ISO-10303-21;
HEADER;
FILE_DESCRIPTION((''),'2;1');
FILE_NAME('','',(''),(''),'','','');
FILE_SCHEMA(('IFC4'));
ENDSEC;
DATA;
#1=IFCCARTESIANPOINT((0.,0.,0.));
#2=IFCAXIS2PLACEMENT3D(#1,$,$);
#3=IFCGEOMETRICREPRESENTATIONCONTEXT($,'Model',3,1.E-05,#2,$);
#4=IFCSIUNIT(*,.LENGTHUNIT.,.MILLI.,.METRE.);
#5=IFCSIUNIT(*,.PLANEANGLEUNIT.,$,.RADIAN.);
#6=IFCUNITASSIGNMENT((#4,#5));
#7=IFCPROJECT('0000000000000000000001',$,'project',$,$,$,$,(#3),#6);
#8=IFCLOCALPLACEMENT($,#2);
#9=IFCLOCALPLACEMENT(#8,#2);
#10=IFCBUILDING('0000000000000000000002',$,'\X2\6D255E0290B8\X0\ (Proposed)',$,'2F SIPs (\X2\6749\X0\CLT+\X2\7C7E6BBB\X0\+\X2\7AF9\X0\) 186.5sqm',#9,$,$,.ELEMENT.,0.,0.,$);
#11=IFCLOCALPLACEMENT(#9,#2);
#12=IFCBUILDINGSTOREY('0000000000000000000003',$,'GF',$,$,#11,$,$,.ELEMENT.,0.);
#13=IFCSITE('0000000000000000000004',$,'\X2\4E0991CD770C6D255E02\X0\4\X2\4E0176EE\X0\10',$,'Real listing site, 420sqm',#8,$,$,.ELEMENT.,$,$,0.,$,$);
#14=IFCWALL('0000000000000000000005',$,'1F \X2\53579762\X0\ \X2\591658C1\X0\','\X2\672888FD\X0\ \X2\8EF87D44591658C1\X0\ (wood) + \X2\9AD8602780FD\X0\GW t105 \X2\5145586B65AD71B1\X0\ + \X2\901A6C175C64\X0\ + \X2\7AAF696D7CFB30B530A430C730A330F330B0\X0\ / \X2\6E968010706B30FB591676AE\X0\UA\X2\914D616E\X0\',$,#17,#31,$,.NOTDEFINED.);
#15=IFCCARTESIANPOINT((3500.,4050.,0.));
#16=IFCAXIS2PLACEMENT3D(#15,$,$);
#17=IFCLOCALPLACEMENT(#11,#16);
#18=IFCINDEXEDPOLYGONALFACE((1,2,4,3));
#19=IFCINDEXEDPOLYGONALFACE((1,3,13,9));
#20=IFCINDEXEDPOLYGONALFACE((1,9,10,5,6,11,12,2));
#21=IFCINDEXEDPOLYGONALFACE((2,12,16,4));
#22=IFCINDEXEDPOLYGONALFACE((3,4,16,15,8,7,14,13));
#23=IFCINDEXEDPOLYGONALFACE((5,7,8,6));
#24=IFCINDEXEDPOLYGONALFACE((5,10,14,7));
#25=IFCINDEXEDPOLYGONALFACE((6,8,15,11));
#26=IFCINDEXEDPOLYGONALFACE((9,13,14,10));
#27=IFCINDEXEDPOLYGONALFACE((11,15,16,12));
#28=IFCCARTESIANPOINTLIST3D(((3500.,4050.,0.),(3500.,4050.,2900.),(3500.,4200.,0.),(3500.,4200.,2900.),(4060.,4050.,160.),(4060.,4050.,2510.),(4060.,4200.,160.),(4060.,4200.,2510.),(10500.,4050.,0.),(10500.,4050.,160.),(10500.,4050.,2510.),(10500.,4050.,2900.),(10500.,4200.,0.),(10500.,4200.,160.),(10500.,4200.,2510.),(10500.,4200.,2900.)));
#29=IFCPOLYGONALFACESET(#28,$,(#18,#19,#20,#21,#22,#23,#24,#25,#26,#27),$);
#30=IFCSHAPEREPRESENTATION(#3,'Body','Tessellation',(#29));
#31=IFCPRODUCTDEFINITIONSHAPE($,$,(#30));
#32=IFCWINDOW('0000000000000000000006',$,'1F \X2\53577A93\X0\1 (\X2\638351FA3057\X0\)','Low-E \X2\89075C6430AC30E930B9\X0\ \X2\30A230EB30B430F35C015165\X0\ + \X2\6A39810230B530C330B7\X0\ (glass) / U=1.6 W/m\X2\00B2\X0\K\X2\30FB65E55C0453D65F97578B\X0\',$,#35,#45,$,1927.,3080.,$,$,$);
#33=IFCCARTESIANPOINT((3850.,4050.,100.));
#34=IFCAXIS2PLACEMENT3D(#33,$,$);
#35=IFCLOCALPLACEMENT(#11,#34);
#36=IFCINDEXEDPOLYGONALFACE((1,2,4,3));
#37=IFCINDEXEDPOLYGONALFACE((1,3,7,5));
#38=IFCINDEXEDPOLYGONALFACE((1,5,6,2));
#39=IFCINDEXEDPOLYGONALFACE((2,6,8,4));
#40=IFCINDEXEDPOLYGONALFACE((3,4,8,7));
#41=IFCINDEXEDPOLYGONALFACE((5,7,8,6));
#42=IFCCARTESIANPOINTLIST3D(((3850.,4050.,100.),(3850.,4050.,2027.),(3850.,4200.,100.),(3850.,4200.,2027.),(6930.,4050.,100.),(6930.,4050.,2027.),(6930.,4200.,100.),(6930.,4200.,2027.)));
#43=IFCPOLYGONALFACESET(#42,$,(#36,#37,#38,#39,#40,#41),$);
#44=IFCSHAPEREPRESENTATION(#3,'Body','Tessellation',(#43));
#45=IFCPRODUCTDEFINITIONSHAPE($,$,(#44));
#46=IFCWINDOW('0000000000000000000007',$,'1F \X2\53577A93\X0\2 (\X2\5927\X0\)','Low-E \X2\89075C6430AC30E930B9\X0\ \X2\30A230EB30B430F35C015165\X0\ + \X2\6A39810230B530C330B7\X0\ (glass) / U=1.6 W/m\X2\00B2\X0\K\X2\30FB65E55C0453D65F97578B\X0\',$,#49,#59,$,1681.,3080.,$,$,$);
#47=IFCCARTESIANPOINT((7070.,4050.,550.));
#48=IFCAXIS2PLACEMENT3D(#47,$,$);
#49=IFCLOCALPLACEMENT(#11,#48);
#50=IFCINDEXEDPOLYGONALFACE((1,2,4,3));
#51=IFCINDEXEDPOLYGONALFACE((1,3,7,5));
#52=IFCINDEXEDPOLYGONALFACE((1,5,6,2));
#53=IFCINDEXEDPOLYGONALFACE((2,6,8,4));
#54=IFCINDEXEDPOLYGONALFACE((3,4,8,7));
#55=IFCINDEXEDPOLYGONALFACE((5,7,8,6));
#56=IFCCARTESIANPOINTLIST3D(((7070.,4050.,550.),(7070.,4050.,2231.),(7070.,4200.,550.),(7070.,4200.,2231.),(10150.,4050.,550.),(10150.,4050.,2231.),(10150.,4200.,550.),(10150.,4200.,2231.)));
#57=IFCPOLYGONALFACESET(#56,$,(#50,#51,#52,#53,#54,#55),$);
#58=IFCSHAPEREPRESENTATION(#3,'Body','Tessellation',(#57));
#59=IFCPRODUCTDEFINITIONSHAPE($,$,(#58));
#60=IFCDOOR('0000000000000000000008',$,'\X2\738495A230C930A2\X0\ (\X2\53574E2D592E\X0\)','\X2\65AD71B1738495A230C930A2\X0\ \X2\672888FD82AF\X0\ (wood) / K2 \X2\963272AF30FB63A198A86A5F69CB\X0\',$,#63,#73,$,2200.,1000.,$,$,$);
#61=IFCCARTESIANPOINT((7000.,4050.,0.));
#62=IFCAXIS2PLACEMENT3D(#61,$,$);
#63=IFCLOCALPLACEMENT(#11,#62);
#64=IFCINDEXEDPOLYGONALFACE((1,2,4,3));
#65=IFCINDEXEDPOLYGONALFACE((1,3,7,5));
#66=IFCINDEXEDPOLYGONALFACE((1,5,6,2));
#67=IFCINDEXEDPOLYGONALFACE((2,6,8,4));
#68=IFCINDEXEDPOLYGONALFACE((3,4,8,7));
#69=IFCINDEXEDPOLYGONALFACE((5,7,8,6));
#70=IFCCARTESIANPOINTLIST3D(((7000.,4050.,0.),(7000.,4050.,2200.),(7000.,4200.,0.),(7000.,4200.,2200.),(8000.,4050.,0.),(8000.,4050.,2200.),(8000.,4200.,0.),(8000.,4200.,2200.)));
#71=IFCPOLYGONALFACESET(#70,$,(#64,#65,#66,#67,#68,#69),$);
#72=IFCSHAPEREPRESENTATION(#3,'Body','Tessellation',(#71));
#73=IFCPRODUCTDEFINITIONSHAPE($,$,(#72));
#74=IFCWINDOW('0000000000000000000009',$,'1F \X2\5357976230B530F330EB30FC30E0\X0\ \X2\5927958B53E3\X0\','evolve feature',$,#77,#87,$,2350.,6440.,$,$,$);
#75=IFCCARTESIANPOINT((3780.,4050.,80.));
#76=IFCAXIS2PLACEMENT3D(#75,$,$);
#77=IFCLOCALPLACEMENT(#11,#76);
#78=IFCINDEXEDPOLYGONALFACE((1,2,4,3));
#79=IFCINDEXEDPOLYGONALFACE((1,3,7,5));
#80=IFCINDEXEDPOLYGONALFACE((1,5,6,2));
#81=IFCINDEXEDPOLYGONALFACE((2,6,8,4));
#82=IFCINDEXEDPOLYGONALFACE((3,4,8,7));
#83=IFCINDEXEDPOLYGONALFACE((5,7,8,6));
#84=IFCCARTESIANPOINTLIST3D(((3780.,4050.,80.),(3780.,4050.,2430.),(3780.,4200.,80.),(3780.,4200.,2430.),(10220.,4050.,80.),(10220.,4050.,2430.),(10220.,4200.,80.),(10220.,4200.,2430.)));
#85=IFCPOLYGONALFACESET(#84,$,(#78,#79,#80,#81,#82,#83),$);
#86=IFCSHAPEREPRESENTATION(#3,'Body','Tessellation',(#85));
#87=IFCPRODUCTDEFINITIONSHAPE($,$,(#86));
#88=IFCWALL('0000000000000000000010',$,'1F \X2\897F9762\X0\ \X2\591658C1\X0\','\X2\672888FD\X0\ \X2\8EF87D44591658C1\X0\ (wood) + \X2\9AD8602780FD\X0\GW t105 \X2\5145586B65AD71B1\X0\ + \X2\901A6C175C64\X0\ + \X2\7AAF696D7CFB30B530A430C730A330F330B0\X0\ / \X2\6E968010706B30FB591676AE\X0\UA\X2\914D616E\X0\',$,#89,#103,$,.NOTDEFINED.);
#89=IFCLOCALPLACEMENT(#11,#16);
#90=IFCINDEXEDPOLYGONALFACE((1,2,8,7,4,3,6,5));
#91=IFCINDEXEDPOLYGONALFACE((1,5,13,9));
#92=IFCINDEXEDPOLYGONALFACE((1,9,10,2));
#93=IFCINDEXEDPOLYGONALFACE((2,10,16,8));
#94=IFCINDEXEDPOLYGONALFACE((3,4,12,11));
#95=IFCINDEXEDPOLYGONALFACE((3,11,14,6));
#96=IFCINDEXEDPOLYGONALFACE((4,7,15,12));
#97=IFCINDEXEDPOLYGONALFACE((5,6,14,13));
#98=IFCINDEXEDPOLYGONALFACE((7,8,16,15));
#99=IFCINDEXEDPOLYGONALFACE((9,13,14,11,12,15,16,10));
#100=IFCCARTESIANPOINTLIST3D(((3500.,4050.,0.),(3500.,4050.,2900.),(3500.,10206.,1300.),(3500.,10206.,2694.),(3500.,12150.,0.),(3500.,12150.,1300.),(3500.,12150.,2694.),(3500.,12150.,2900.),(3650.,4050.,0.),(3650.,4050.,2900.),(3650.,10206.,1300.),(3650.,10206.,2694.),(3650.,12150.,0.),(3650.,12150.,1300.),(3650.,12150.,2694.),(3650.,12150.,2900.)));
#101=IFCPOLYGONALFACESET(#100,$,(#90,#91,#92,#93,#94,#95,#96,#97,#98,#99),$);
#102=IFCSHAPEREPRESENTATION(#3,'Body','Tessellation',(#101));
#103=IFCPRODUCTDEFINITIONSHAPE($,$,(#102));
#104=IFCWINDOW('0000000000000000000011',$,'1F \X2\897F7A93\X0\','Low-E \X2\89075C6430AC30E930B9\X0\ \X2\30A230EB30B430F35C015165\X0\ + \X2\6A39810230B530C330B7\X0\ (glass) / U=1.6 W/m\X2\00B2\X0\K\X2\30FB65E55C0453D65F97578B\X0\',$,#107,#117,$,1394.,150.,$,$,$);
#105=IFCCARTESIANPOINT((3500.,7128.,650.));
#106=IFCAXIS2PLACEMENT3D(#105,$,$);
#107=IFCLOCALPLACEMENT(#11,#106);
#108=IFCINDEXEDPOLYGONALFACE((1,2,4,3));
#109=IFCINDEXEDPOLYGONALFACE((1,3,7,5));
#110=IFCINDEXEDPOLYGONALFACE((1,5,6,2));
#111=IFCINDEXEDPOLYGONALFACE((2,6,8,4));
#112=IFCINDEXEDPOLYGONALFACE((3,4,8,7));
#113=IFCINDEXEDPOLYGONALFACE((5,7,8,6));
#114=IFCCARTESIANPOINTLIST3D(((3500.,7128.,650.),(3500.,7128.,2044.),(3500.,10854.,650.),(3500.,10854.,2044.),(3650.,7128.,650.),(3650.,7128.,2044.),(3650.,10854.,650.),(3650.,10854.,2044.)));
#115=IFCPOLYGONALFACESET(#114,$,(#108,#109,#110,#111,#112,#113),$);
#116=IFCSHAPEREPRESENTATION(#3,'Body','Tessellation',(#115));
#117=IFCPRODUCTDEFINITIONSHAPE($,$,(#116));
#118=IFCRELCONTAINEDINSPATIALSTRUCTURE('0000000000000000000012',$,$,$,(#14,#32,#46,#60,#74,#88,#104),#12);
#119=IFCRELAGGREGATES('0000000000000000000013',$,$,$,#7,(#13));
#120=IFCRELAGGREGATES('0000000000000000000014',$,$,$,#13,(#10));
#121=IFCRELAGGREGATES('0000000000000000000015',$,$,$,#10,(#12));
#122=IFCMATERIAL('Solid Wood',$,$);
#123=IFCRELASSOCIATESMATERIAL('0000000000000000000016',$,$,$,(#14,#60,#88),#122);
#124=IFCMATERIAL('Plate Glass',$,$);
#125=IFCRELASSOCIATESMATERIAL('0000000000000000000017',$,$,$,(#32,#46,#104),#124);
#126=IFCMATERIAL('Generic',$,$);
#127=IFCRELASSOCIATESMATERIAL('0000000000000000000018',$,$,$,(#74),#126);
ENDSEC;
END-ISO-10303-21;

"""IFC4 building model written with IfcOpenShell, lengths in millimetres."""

from ifc_helpers import new_model, si_unit, frame, frame_2d, origin, place, context, project, spatial, rectangle, extrude, material, element, fill, save


model = new_model("IFC4")

# Units and contexts
model_context = context("Model", 3, precision=1e-05, world=origin())
ifc_project = project(units=[si_unit("LENGTHUNIT", "METRE", prefix="MILLI"), si_unit("PLANEANGLEUNIT", "RADIAN")], contexts=[model_context])

# Site, building, storey
site_placement = place(None, origin())
site = spatial("IfcSite", under=ifc_project, at=site_placement, Name="三重県津市4丁目10", ObjectType="Real listing site, 420sqm", CompositionType="ELEMENT", RefElevation=0.0)
building_placement = place(site_placement, origin())
building = spatial("IfcBuilding", under=site, at=building_placement, Name="津市邸 (Proposed)", ObjectType="2F SIPs (杉CLT+籾殻+竹) 186.5sqm", CompositionType="ELEMENT", ElevationOfRefHeight=0.0, ElevationOfTerrain=0.0)
storey_placement = place(building_placement, origin())
storey = spatial("IfcBuildingStorey", under=building, at=storey_placement, Name="GF", CompositionType="ELEMENT", Elevation=0.0)

# Shared definitions
ifc_material_1 = material(Name="Solid Wood")
ifc_material_2 = material(Name="Generic")

# Wall, openings, windows, door
wall_1_placement = place(storey_placement, frame((3500.0, 4050.0, 0.0)))
wall_1 = element("IfcWall", 1, at=wall_1_placement, inside=storey, material=ifc_material_1, Name="1F 南面 外壁", Description="木製 軸組外壁 (wood) + 高性能GW t105 充填断熱 + 通気層 + 窯業系サイディング / 準耐火・外皮UA配慮", PredefinedType="NOTDEFINED", context=model_context, shape_type="SweptSolid", body=[
    extrude(rectangle(XDim=7000.0, YDim=150.0, at=frame_2d((3500.0, 75.0))), frame((3500.0, 4050.0, 0.0)), (0.0, 0.0, 1.0), 2900.0),
])
opening_1_placement = place(storey_placement, frame((3850.0, 4050.0, 100.0)))
opening_1 = element("IfcOpeningElement", 2, at=opening_1_placement, cuts=wall_1, PredefinedType="NOTDEFINED", context=model_context, shape_type="SweptSolid", body=[
    extrude(rectangle(XDim=3080.0, YDim=150.0, at=frame_2d((1540.0, 75.0))), frame((3850.0, 4050.0, 100.0)), (0.0, 0.0, 1.0), 1927.0),
])
opening_2_placement = place(storey_placement, frame((7070.0, 4050.0, 550.0)))
opening_2 = element("IfcOpeningElement", 3, at=opening_2_placement, cuts=wall_1, PredefinedType="NOTDEFINED", context=model_context, shape_type="SweptSolid", body=[
    extrude(rectangle(XDim=3080.0, YDim=150.0, at=frame_2d((1540.0, 75.0))), frame((7070.0, 4050.0, 550.0)), (0.0, 0.0, 1.0), 1681.0),
])
opening_3_placement = place(storey_placement, frame((7000.0, 4050.0, 0.0)))
opening_3 = element("IfcOpeningElement", 4, at=opening_3_placement, cuts=wall_1, PredefinedType="NOTDEFINED", context=model_context, shape_type="SweptSolid", body=[
    extrude(rectangle(XDim=1000.0, YDim=150.0, at=frame_2d((500.0, 75.0))), frame((7000.0, 4050.0, 0.0)), (0.0, 0.0, 1.0), 2200.0),
])
opening_4_placement = place(storey_placement, frame((3780.0, 4050.0, 80.0)))
opening_4 = element("IfcOpeningElement", 5, at=opening_4_placement, cuts=wall_1, PredefinedType="NOTDEFINED", context=model_context, shape_type="SweptSolid", body=[
    extrude(rectangle(XDim=6440.0, YDim=150.0, at=frame_2d((3220.0, 75.0))), frame((3780.0, 4050.0, 80.0)), (0.0, 0.0, 1.0), 2350.0),
])
ifc_material_3 = material(Name="Plate Glass")
window_1_placement = place(storey_placement, frame((3850.0, 4050.0, 100.0)))
window_1 = element("IfcWindow", 6, at=window_1_placement, inside=storey, material=ifc_material_3, Name="1F 南窓1 (掃出し)", Description="Low-E 複層ガラス アルゴン封入 + 樹脂サッシ (glass) / U=1.6 W/m²K・日射取得型", OverallHeight=1927.0, OverallWidth=3080.0, context=model_context, shape_type="SweptSolid", body=[
    extrude(rectangle(XDim=3080.0, YDim=150.0, at=frame_2d((1540.0, 75.0))), frame((3850.0, 4050.0, 100.0)), (0.0, 0.0, 1.0), 1927.0),
])
fill(opening_1, window_1)
window_2_placement = place(storey_placement, frame((7070.0, 4050.0, 550.0)))
window_2 = element("IfcWindow", 7, at=window_2_placement, inside=storey, material=ifc_material_3, Name="1F 南窓2 (大)", Description="Low-E 複層ガラス アルゴン封入 + 樹脂サッシ (glass) / U=1.6 W/m²K・日射取得型", OverallHeight=1681.0, OverallWidth=3080.0, context=model_context, shape_type="SweptSolid", body=[
    extrude(rectangle(XDim=3080.0, YDim=150.0, at=frame_2d((1540.0, 75.0))), frame((7070.0, 4050.0, 550.0)), (0.0, 0.0, 1.0), 1681.0),
])
fill(opening_2, window_2)
door_placement = place(storey_placement, frame((7000.0, 4050.0, 0.0)))
door = element("IfcDoor", 8, at=door_placement, inside=storey, material=ifc_material_1, Name="玄関ドア (南中央)", Description="断熱玄関ドア 木製芯 (wood) / K2 防犯・採風機構", OverallHeight=2200.0, OverallWidth=1000.0, context=model_context, shape_type="SweptSolid", body=[
    extrude(rectangle(XDim=1000.0, YDim=150.0, at=frame_2d((500.0, 75.0))), frame((7000.0, 4050.0, 0.0)), (0.0, 0.0, 1.0), 2200.0),
])
fill(opening_3, door)
window_3_placement = place(storey_placement, frame((3780.0, 4050.0, 80.0)))
window_3 = element("IfcWindow", 9, at=window_3_placement, inside=storey, material=ifc_material_2, Name="1F 南面サンルーム 大開口", Description="evolve feature", OverallHeight=2350.0, OverallWidth=6440.0, context=model_context, shape_type="SweptSolid", body=[
    extrude(rectangle(XDim=6440.0, YDim=150.0, at=frame_2d((3220.0, 75.0))), frame((3780.0, 4050.0, 80.0)), (0.0, 0.0, 1.0), 2350.0),
])
fill(opening_4, window_3)

# Wall, opening, window
wall_2_placement = place(storey_placement, frame((3500.0, 4050.0, 0.0)))
wall_2 = element("IfcWall", 10, at=wall_2_placement, inside=storey, material=ifc_material_1, Name="1F 西面 外壁", Description="木製 軸組外壁 (wood) + 高性能GW t105 充填断熱 + 通気層 + 窯業系サイディング / 準耐火・外皮UA配慮", PredefinedType="NOTDEFINED", context=model_context, shape_type="SweptSolid", body=[
    extrude(rectangle(XDim=150.0, YDim=8100.0, at=frame_2d((75.0, 4050.0))), frame((3500.0, 4050.0, 0.0)), (0.0, 0.0, 1.0), 2900.0),
])
opening_5_placement = place(storey_placement, frame((3500.0, 7128.0, 650.0)))
opening_5 = element("IfcOpeningElement", 11, at=opening_5_placement, cuts=wall_2, PredefinedType="NOTDEFINED", context=model_context, shape_type="SweptSolid", body=[
    extrude(rectangle(XDim=150.0, YDim=3726.0, at=frame_2d((75.0, 1863.0))), frame((3500.0, 7128.0, 650.0)), (0.0, 0.0, 1.0), 1394.0),
])
window_4_placement = place(storey_placement, frame((3500.0, 7128.0, 650.0)))
window_4 = element("IfcWindow", 12, at=window_4_placement, inside=storey, material=ifc_material_3, Name="1F 西窓", Description="Low-E 複層ガラス アルゴン封入 + 樹脂サッシ (glass) / U=1.6 W/m²K・日射取得型", OverallHeight=1394.0, OverallWidth=150.0, context=model_context, shape_type="SweptSolid", body=[
    extrude(rectangle(XDim=150.0, YDim=3726.0, at=frame_2d((75.0, 1863.0))), frame((3500.0, 7128.0, 650.0)), (0.0, 0.0, 1.0), 1394.0),
])
fill(opening_5, window_4)

save(model, "model.ifc")
